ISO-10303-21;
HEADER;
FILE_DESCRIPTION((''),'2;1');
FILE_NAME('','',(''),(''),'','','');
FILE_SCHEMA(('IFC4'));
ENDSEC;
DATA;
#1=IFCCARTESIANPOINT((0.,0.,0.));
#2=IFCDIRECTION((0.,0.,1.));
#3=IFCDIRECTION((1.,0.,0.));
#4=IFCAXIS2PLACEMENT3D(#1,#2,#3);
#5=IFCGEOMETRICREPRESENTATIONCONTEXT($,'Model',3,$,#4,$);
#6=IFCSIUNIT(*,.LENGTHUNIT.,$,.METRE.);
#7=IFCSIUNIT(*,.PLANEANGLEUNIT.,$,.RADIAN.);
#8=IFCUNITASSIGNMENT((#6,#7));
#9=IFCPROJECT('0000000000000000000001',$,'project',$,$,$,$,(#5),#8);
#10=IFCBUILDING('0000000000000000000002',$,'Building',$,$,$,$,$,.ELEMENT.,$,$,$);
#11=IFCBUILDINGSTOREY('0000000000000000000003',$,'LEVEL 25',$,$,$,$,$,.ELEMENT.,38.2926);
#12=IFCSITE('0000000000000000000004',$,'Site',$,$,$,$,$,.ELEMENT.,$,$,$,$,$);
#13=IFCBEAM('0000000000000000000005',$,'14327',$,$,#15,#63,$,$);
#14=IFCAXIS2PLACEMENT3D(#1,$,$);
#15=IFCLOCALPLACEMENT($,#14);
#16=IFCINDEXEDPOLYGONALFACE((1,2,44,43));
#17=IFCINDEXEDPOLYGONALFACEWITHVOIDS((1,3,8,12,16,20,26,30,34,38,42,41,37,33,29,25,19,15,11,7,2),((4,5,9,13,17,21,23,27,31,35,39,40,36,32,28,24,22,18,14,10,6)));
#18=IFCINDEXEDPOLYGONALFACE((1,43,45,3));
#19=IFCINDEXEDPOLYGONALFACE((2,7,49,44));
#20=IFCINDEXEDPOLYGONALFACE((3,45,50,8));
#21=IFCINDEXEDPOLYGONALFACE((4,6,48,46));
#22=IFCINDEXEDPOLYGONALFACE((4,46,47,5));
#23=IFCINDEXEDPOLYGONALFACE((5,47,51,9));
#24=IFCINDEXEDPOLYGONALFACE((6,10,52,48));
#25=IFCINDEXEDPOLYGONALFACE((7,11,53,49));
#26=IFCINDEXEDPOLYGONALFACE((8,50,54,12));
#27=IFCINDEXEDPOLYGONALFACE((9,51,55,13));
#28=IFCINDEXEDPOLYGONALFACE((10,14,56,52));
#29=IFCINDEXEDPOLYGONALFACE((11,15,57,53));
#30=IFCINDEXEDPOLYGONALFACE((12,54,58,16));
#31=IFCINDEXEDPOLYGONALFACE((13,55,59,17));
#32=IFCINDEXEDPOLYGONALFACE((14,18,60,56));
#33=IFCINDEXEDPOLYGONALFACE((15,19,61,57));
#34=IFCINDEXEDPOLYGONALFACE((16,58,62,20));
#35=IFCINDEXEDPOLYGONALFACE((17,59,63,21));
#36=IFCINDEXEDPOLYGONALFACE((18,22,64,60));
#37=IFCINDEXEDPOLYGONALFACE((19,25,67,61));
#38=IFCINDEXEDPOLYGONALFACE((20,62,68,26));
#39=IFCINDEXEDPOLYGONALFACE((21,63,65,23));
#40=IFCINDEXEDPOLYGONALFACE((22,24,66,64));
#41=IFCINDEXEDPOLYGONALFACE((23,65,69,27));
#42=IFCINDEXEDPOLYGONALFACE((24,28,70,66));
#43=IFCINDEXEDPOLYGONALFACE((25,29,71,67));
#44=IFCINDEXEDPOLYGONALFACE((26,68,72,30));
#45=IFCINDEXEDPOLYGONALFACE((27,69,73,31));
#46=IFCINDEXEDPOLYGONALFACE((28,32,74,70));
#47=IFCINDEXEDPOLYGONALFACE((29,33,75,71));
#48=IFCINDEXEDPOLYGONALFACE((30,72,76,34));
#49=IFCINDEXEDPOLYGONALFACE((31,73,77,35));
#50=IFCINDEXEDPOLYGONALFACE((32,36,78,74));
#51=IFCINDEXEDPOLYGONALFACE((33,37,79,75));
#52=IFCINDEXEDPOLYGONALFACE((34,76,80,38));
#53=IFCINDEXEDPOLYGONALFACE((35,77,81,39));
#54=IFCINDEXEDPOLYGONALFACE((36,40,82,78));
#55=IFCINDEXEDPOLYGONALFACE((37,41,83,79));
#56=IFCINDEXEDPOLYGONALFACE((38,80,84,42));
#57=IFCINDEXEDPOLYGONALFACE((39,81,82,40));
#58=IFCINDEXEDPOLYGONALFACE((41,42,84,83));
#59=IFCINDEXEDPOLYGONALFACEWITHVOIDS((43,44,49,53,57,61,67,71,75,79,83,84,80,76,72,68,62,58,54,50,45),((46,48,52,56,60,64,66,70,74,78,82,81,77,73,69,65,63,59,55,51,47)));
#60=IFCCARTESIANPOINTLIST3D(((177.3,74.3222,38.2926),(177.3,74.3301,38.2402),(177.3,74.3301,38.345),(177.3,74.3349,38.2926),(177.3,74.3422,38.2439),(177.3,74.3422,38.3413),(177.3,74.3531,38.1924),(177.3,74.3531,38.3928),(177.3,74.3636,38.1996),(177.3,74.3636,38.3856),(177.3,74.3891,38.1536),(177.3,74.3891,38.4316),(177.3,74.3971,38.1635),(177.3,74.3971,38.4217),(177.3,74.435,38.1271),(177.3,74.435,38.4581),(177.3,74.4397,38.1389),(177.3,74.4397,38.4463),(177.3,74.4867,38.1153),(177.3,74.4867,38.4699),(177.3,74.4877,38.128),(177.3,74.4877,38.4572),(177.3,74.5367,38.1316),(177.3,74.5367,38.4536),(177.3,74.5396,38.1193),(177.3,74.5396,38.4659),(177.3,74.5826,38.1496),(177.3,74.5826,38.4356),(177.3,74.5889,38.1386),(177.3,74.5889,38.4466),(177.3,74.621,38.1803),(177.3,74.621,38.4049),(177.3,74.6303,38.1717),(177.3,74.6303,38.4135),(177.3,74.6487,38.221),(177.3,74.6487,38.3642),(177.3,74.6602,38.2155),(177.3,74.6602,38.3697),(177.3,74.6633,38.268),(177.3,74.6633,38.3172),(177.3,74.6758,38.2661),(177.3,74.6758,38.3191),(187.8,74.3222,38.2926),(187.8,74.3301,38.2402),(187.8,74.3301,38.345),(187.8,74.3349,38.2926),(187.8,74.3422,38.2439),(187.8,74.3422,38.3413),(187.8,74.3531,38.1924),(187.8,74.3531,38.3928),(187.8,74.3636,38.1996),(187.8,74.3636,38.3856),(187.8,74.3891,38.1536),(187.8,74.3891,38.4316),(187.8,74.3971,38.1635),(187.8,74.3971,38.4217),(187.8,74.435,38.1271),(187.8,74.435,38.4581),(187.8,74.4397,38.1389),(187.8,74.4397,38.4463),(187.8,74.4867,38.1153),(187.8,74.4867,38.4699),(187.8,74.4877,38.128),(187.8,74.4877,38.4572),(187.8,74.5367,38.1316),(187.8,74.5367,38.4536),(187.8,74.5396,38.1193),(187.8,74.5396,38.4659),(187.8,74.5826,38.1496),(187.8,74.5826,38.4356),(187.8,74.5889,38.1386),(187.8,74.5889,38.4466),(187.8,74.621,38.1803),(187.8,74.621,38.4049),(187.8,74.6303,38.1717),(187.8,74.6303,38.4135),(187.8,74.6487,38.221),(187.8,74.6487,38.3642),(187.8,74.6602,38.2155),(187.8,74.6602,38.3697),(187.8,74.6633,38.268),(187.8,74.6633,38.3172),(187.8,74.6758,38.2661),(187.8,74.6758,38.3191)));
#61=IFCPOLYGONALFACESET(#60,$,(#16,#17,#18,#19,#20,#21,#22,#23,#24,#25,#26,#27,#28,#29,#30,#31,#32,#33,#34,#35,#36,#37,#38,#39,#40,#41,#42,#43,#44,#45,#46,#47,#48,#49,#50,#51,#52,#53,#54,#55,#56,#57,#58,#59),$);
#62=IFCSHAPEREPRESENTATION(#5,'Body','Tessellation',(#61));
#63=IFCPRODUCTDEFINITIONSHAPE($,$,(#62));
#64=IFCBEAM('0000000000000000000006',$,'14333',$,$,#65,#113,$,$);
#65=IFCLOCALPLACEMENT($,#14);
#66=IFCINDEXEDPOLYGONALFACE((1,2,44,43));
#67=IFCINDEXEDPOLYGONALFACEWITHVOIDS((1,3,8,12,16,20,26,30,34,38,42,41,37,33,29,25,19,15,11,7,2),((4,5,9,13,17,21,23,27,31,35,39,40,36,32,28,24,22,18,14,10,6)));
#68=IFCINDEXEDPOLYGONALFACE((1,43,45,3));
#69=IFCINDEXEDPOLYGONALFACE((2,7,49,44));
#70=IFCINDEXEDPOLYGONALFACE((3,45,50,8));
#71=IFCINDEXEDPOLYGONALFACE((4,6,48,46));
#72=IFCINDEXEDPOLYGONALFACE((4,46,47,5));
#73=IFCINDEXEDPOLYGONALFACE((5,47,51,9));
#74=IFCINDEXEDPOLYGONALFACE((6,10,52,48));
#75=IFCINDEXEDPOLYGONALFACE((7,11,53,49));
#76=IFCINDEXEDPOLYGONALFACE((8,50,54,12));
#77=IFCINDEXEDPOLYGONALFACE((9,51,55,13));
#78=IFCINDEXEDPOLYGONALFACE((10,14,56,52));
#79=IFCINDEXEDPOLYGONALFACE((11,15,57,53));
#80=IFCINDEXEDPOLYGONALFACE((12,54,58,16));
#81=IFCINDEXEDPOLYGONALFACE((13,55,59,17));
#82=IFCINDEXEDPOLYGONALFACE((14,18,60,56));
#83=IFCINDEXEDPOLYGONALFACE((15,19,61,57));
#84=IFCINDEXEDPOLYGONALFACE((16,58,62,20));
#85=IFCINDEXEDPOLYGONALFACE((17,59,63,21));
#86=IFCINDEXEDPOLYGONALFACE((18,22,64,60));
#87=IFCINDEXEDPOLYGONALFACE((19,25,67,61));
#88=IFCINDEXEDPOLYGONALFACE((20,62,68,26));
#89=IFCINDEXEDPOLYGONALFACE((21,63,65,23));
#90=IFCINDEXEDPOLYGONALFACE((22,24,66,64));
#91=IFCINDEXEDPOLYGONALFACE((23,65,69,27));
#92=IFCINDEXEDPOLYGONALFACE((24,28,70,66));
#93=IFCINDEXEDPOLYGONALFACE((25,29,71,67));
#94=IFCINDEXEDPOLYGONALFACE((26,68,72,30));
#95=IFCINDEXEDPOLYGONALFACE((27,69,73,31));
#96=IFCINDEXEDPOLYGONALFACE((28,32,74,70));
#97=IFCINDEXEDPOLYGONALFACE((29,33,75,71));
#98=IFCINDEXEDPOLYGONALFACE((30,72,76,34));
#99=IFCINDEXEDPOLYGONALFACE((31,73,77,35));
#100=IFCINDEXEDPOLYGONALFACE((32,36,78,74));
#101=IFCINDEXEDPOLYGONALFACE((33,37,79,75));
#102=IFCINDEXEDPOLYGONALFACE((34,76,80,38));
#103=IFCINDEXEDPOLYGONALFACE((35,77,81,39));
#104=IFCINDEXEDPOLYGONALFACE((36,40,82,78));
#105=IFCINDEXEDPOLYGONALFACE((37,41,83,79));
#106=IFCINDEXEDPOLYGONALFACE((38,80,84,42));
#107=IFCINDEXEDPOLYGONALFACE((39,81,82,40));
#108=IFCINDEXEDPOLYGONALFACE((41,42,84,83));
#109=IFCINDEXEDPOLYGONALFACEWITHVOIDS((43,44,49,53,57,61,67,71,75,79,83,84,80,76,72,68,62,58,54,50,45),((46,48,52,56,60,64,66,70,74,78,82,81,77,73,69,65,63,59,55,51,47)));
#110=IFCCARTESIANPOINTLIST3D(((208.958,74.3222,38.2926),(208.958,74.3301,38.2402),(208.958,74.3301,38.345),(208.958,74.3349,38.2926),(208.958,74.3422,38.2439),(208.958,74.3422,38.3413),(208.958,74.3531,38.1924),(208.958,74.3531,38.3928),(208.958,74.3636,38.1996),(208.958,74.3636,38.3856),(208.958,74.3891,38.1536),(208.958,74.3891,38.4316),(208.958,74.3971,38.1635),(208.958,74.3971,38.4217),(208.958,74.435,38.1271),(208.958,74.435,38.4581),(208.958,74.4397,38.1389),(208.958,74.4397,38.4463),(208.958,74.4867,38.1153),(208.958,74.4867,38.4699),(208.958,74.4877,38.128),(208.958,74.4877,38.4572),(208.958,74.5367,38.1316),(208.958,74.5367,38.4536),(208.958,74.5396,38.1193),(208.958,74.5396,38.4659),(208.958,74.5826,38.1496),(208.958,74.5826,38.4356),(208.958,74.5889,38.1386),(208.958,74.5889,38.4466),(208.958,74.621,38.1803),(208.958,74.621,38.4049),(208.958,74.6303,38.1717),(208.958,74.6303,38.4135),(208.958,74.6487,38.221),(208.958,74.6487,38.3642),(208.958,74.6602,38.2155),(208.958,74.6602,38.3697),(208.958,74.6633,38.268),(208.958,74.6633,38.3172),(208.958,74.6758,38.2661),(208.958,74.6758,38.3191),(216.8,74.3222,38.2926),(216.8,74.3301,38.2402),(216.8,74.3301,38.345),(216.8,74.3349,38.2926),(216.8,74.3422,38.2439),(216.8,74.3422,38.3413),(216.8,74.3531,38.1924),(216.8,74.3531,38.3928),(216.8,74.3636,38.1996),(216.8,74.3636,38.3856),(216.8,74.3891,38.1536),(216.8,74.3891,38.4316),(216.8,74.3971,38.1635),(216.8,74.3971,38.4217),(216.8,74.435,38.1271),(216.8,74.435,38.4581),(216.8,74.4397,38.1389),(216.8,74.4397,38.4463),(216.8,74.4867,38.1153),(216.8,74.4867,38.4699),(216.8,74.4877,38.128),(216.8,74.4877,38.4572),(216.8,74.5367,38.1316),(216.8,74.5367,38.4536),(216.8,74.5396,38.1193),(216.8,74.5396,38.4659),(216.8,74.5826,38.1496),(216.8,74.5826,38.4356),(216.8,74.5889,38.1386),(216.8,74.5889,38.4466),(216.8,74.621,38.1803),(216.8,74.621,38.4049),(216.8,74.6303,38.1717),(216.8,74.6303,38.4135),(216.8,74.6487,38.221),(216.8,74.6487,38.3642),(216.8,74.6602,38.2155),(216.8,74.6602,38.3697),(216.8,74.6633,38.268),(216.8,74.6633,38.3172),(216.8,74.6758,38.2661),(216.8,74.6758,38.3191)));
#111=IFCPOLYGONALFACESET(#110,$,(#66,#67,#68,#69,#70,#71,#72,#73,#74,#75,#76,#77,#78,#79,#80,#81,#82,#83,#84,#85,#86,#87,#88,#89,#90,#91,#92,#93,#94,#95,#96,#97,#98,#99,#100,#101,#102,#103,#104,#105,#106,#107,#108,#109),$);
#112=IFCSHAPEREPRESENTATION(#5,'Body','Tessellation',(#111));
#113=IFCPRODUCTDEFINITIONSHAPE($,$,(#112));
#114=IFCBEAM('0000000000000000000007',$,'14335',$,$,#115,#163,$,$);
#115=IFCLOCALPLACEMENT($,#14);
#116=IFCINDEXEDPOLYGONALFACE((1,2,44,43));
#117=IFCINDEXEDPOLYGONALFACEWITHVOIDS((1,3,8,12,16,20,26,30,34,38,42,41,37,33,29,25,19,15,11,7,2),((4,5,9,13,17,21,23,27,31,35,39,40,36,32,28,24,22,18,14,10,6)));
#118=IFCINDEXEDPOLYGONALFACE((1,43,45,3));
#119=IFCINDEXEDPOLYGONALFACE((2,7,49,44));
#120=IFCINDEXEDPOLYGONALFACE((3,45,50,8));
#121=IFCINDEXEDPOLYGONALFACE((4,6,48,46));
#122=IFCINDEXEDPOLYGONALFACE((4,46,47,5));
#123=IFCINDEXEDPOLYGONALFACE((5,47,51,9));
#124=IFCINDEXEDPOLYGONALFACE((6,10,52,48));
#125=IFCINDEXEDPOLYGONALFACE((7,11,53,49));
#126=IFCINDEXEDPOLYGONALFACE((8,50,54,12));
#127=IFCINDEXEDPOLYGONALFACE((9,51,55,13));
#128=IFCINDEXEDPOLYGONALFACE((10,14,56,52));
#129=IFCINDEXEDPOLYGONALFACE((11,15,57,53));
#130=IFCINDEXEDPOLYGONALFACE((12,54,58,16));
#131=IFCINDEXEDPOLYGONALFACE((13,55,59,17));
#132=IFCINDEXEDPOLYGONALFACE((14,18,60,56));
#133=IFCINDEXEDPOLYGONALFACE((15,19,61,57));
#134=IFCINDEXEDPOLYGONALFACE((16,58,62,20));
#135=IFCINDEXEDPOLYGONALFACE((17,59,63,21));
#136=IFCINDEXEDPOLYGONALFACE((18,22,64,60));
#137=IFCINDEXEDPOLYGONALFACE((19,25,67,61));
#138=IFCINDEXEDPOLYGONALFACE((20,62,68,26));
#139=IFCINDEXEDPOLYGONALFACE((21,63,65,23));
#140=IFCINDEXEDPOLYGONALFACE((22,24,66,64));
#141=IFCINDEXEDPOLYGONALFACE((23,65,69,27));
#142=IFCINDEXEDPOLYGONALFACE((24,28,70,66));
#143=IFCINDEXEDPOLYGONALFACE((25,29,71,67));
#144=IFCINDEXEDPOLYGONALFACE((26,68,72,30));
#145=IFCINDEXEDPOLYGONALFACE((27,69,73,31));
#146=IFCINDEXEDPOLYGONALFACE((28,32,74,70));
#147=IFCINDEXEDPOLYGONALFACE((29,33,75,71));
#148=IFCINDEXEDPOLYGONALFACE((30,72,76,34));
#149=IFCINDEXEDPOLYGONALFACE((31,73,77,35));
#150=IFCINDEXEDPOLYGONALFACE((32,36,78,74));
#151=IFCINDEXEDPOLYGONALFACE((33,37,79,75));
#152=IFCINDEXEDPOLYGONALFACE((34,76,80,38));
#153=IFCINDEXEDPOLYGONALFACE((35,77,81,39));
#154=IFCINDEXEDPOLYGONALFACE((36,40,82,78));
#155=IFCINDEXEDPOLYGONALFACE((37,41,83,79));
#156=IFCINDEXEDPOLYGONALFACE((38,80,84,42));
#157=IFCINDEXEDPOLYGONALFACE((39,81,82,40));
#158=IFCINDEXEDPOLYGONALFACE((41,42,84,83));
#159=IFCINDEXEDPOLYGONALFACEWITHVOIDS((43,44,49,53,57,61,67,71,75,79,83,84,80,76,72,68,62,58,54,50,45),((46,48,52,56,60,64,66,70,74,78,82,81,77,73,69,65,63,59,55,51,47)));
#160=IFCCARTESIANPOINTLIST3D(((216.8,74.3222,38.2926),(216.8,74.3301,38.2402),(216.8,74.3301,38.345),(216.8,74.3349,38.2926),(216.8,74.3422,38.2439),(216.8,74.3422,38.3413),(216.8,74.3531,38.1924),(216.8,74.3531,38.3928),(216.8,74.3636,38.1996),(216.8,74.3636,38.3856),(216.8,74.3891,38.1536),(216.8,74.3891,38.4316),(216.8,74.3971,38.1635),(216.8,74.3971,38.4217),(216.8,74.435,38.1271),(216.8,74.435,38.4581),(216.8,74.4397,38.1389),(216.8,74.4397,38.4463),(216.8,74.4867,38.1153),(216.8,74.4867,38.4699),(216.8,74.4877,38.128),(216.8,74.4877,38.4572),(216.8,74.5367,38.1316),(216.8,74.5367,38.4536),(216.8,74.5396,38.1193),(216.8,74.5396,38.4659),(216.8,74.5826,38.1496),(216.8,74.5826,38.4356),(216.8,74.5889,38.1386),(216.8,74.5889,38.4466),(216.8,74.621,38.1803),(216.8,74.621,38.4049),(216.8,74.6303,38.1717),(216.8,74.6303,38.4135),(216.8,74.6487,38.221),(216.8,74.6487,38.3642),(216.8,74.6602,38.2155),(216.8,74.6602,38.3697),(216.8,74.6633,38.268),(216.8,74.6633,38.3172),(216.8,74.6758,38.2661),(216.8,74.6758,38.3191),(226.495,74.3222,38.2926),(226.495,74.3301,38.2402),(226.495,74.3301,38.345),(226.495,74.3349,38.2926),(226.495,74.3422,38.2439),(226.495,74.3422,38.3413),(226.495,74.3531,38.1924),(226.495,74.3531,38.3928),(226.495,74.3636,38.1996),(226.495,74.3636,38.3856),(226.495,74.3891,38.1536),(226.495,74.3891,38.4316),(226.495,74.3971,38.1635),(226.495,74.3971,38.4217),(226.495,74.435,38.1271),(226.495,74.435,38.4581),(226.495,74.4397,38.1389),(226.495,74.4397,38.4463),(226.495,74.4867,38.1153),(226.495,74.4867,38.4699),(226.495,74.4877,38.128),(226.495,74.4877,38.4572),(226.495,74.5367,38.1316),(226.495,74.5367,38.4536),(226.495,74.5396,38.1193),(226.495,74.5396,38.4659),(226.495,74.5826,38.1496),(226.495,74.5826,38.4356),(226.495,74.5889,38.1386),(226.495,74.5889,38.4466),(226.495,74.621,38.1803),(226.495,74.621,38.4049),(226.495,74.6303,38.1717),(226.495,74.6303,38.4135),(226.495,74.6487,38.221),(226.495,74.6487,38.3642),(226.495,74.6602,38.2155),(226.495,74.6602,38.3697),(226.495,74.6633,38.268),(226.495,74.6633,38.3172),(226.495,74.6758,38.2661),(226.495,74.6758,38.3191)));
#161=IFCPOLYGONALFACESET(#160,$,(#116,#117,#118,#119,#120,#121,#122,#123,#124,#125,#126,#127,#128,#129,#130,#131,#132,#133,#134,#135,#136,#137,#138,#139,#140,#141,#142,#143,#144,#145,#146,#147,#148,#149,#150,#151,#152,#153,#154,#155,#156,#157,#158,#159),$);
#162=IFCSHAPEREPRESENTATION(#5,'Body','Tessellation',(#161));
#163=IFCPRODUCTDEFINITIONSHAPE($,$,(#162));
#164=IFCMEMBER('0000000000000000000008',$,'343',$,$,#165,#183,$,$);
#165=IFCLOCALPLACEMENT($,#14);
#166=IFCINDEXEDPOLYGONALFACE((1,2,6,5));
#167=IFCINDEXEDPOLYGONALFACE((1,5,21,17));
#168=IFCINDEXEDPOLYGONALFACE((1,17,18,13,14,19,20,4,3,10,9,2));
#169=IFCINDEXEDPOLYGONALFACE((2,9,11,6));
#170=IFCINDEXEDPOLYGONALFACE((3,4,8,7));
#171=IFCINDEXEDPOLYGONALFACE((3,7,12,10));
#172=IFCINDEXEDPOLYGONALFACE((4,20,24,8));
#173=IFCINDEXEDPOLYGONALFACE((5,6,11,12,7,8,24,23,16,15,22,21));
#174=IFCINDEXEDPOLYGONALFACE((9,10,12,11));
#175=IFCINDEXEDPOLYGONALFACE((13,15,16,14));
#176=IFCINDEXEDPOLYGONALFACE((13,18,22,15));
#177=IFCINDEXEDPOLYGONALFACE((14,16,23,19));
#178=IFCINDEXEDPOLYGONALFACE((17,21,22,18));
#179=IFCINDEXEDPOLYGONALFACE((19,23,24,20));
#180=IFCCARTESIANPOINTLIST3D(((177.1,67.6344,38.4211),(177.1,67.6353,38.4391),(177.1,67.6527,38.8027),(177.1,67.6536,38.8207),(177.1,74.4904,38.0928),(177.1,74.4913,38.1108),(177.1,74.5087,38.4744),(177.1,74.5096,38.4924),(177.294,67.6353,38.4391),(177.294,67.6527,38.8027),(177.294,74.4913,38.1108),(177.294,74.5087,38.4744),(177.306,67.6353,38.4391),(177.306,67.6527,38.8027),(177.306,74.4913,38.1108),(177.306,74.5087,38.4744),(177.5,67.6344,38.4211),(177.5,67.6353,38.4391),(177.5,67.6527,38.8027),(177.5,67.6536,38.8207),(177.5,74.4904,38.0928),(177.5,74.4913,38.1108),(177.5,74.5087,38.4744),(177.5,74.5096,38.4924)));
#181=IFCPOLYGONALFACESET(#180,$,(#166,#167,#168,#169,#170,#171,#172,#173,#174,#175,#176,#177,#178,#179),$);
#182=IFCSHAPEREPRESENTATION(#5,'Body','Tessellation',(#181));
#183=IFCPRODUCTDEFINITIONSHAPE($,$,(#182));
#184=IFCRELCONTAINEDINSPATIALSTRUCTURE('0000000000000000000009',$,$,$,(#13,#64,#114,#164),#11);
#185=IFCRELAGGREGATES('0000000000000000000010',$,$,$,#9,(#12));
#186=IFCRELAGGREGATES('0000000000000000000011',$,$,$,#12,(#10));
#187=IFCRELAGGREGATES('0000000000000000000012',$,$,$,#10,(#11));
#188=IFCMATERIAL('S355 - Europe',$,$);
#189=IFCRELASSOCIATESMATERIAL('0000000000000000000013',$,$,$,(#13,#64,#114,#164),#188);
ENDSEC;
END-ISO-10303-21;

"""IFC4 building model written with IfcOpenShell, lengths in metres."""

from ifc_helpers import new_model, si_unit, frame, origin_with_axes, origin_2d_with_axis, place, context, project, spatial, hollow_circle, i_section, extrude, material, material_profile, profile_set, profile_usage, element, save


model = new_model("IFC4")

# Units and contexts
model_context = context("Model", 3, world=origin_with_axes())
ifc_project = project(units=[si_unit("LENGTHUNIT", "METRE"), si_unit("PLANEANGLEUNIT", "RADIAN")], contexts=[model_context])

# Site, building, storey
site = spatial("IfcSite", under=ifc_project, Name="Site", CompositionType="ELEMENT")
building = spatial("IfcBuilding", under=site, Name="Building", CompositionType="ELEMENT")
storey = spatial("IfcBuildingStorey", under=building, Name="LEVEL 25", CompositionType="ELEMENT", Elevation=38.2926)

# Beams
ifc_material = material(Name="S355 - Europe")
ifc_material_profile_1 = material_profile(ifc_material, hollow_circle(Radius=0.1778, WallThickness=0.0127, at=origin_2d_with_axis()))
ifc_profile_set_1 = profile_set([ifc_material_profile_1])
ifc_profile_usage_1 = profile_usage(ifc_profile_set_1, cardinal=10)
beam_1_placement = place(None, frame((187.8, 74.5, 38.2926), z_axis=(-1.0, 0.0, 0.0), x_axis=(0.0, -1.0, 0.0)))
element("IfcBeam", 1, at=beam_1_placement, inside=storey, material=ifc_profile_usage_1, Name="14327", context=model_context, shape_type="SweptSolid", body=[
    extrude(hollow_circle(Radius=0.1778, WallThickness=0.0127, at=origin_2d_with_axis()), origin_with_axes(), (0.0, 0.0, 1.0), 10.5),
])
ifc_material_profile_2 = material_profile(ifc_material, hollow_circle(Radius=0.1778, WallThickness=0.0127, at=origin_2d_with_axis()))
ifc_profile_set_2 = profile_set([ifc_material_profile_2])
ifc_profile_usage_2 = profile_usage(ifc_profile_set_2, cardinal=10)
beam_2_placement = place(None, frame((216.8, 74.5, 38.2926), z_axis=(-1.0, 0.0, 0.0), x_axis=(0.0, -1.0, 0.0)))
element("IfcBeam", 2, at=beam_2_placement, inside=storey, material=ifc_profile_usage_2, Name="14333", context=model_context, shape_type="SweptSolid", body=[
    extrude(hollow_circle(Radius=0.1778, WallThickness=0.0127, at=origin_2d_with_axis()), origin_with_axes(), (0.0, 0.0, 1.0), 7.842),
])
ifc_material_profile_3 = material_profile(ifc_material, hollow_circle(Radius=0.1778, WallThickness=0.0127, at=origin_2d_with_axis()))
ifc_profile_set_3 = profile_set([ifc_material_profile_3])
ifc_profile_usage_3 = profile_usage(ifc_profile_set_3, cardinal=10)
beam_3_placement = place(None, frame((226.495, 74.5, 38.2926), z_axis=(-1.0, 0.0, 0.0), x_axis=(0.0, -1.0, 0.0)))
element("IfcBeam", 3, at=beam_3_placement, inside=storey, material=ifc_profile_usage_3, Name="14335", context=model_context, shape_type="SweptSolid", body=[
    extrude(hollow_circle(Radius=0.1778, WallThickness=0.0127, at=origin_2d_with_axis()), origin_with_axes(), (0.0, 0.0, 1.0), 9.695),
])

# Member
ifc_material_profile_4 = material_profile(ifc_material, i_section(OverallWidth=0.4, OverallDepth=0.4, WebThickness=0.012, FlangeThickness=0.018, at=origin_2d_with_axis()))
ifc_profile_set_4 = profile_set([ifc_material_profile_4])
ifc_profile_usage_4 = profile_usage(ifc_profile_set_4, cardinal=10)
member_1_placement = place(None, frame((177.3, 74.5, 38.2926), z_axis=(0.0, -0.998856, 0.047828), x_axis=(1.0, 0.0, 0.0)))
element("IfcMember", 4, at=member_1_placement, inside=storey, material=ifc_profile_usage_4, Name="343", context=model_context, shape_type="SweptSolid", body=[
    extrude(i_section(OverallWidth=0.4, OverallDepth=0.4, WebThickness=0.012, FlangeThickness=0.018, at=origin_2d_with_axis()), origin_with_axes(), (0.0, 0.0, 1.0), 6.8639),
])

save(model, "model.ifc")
